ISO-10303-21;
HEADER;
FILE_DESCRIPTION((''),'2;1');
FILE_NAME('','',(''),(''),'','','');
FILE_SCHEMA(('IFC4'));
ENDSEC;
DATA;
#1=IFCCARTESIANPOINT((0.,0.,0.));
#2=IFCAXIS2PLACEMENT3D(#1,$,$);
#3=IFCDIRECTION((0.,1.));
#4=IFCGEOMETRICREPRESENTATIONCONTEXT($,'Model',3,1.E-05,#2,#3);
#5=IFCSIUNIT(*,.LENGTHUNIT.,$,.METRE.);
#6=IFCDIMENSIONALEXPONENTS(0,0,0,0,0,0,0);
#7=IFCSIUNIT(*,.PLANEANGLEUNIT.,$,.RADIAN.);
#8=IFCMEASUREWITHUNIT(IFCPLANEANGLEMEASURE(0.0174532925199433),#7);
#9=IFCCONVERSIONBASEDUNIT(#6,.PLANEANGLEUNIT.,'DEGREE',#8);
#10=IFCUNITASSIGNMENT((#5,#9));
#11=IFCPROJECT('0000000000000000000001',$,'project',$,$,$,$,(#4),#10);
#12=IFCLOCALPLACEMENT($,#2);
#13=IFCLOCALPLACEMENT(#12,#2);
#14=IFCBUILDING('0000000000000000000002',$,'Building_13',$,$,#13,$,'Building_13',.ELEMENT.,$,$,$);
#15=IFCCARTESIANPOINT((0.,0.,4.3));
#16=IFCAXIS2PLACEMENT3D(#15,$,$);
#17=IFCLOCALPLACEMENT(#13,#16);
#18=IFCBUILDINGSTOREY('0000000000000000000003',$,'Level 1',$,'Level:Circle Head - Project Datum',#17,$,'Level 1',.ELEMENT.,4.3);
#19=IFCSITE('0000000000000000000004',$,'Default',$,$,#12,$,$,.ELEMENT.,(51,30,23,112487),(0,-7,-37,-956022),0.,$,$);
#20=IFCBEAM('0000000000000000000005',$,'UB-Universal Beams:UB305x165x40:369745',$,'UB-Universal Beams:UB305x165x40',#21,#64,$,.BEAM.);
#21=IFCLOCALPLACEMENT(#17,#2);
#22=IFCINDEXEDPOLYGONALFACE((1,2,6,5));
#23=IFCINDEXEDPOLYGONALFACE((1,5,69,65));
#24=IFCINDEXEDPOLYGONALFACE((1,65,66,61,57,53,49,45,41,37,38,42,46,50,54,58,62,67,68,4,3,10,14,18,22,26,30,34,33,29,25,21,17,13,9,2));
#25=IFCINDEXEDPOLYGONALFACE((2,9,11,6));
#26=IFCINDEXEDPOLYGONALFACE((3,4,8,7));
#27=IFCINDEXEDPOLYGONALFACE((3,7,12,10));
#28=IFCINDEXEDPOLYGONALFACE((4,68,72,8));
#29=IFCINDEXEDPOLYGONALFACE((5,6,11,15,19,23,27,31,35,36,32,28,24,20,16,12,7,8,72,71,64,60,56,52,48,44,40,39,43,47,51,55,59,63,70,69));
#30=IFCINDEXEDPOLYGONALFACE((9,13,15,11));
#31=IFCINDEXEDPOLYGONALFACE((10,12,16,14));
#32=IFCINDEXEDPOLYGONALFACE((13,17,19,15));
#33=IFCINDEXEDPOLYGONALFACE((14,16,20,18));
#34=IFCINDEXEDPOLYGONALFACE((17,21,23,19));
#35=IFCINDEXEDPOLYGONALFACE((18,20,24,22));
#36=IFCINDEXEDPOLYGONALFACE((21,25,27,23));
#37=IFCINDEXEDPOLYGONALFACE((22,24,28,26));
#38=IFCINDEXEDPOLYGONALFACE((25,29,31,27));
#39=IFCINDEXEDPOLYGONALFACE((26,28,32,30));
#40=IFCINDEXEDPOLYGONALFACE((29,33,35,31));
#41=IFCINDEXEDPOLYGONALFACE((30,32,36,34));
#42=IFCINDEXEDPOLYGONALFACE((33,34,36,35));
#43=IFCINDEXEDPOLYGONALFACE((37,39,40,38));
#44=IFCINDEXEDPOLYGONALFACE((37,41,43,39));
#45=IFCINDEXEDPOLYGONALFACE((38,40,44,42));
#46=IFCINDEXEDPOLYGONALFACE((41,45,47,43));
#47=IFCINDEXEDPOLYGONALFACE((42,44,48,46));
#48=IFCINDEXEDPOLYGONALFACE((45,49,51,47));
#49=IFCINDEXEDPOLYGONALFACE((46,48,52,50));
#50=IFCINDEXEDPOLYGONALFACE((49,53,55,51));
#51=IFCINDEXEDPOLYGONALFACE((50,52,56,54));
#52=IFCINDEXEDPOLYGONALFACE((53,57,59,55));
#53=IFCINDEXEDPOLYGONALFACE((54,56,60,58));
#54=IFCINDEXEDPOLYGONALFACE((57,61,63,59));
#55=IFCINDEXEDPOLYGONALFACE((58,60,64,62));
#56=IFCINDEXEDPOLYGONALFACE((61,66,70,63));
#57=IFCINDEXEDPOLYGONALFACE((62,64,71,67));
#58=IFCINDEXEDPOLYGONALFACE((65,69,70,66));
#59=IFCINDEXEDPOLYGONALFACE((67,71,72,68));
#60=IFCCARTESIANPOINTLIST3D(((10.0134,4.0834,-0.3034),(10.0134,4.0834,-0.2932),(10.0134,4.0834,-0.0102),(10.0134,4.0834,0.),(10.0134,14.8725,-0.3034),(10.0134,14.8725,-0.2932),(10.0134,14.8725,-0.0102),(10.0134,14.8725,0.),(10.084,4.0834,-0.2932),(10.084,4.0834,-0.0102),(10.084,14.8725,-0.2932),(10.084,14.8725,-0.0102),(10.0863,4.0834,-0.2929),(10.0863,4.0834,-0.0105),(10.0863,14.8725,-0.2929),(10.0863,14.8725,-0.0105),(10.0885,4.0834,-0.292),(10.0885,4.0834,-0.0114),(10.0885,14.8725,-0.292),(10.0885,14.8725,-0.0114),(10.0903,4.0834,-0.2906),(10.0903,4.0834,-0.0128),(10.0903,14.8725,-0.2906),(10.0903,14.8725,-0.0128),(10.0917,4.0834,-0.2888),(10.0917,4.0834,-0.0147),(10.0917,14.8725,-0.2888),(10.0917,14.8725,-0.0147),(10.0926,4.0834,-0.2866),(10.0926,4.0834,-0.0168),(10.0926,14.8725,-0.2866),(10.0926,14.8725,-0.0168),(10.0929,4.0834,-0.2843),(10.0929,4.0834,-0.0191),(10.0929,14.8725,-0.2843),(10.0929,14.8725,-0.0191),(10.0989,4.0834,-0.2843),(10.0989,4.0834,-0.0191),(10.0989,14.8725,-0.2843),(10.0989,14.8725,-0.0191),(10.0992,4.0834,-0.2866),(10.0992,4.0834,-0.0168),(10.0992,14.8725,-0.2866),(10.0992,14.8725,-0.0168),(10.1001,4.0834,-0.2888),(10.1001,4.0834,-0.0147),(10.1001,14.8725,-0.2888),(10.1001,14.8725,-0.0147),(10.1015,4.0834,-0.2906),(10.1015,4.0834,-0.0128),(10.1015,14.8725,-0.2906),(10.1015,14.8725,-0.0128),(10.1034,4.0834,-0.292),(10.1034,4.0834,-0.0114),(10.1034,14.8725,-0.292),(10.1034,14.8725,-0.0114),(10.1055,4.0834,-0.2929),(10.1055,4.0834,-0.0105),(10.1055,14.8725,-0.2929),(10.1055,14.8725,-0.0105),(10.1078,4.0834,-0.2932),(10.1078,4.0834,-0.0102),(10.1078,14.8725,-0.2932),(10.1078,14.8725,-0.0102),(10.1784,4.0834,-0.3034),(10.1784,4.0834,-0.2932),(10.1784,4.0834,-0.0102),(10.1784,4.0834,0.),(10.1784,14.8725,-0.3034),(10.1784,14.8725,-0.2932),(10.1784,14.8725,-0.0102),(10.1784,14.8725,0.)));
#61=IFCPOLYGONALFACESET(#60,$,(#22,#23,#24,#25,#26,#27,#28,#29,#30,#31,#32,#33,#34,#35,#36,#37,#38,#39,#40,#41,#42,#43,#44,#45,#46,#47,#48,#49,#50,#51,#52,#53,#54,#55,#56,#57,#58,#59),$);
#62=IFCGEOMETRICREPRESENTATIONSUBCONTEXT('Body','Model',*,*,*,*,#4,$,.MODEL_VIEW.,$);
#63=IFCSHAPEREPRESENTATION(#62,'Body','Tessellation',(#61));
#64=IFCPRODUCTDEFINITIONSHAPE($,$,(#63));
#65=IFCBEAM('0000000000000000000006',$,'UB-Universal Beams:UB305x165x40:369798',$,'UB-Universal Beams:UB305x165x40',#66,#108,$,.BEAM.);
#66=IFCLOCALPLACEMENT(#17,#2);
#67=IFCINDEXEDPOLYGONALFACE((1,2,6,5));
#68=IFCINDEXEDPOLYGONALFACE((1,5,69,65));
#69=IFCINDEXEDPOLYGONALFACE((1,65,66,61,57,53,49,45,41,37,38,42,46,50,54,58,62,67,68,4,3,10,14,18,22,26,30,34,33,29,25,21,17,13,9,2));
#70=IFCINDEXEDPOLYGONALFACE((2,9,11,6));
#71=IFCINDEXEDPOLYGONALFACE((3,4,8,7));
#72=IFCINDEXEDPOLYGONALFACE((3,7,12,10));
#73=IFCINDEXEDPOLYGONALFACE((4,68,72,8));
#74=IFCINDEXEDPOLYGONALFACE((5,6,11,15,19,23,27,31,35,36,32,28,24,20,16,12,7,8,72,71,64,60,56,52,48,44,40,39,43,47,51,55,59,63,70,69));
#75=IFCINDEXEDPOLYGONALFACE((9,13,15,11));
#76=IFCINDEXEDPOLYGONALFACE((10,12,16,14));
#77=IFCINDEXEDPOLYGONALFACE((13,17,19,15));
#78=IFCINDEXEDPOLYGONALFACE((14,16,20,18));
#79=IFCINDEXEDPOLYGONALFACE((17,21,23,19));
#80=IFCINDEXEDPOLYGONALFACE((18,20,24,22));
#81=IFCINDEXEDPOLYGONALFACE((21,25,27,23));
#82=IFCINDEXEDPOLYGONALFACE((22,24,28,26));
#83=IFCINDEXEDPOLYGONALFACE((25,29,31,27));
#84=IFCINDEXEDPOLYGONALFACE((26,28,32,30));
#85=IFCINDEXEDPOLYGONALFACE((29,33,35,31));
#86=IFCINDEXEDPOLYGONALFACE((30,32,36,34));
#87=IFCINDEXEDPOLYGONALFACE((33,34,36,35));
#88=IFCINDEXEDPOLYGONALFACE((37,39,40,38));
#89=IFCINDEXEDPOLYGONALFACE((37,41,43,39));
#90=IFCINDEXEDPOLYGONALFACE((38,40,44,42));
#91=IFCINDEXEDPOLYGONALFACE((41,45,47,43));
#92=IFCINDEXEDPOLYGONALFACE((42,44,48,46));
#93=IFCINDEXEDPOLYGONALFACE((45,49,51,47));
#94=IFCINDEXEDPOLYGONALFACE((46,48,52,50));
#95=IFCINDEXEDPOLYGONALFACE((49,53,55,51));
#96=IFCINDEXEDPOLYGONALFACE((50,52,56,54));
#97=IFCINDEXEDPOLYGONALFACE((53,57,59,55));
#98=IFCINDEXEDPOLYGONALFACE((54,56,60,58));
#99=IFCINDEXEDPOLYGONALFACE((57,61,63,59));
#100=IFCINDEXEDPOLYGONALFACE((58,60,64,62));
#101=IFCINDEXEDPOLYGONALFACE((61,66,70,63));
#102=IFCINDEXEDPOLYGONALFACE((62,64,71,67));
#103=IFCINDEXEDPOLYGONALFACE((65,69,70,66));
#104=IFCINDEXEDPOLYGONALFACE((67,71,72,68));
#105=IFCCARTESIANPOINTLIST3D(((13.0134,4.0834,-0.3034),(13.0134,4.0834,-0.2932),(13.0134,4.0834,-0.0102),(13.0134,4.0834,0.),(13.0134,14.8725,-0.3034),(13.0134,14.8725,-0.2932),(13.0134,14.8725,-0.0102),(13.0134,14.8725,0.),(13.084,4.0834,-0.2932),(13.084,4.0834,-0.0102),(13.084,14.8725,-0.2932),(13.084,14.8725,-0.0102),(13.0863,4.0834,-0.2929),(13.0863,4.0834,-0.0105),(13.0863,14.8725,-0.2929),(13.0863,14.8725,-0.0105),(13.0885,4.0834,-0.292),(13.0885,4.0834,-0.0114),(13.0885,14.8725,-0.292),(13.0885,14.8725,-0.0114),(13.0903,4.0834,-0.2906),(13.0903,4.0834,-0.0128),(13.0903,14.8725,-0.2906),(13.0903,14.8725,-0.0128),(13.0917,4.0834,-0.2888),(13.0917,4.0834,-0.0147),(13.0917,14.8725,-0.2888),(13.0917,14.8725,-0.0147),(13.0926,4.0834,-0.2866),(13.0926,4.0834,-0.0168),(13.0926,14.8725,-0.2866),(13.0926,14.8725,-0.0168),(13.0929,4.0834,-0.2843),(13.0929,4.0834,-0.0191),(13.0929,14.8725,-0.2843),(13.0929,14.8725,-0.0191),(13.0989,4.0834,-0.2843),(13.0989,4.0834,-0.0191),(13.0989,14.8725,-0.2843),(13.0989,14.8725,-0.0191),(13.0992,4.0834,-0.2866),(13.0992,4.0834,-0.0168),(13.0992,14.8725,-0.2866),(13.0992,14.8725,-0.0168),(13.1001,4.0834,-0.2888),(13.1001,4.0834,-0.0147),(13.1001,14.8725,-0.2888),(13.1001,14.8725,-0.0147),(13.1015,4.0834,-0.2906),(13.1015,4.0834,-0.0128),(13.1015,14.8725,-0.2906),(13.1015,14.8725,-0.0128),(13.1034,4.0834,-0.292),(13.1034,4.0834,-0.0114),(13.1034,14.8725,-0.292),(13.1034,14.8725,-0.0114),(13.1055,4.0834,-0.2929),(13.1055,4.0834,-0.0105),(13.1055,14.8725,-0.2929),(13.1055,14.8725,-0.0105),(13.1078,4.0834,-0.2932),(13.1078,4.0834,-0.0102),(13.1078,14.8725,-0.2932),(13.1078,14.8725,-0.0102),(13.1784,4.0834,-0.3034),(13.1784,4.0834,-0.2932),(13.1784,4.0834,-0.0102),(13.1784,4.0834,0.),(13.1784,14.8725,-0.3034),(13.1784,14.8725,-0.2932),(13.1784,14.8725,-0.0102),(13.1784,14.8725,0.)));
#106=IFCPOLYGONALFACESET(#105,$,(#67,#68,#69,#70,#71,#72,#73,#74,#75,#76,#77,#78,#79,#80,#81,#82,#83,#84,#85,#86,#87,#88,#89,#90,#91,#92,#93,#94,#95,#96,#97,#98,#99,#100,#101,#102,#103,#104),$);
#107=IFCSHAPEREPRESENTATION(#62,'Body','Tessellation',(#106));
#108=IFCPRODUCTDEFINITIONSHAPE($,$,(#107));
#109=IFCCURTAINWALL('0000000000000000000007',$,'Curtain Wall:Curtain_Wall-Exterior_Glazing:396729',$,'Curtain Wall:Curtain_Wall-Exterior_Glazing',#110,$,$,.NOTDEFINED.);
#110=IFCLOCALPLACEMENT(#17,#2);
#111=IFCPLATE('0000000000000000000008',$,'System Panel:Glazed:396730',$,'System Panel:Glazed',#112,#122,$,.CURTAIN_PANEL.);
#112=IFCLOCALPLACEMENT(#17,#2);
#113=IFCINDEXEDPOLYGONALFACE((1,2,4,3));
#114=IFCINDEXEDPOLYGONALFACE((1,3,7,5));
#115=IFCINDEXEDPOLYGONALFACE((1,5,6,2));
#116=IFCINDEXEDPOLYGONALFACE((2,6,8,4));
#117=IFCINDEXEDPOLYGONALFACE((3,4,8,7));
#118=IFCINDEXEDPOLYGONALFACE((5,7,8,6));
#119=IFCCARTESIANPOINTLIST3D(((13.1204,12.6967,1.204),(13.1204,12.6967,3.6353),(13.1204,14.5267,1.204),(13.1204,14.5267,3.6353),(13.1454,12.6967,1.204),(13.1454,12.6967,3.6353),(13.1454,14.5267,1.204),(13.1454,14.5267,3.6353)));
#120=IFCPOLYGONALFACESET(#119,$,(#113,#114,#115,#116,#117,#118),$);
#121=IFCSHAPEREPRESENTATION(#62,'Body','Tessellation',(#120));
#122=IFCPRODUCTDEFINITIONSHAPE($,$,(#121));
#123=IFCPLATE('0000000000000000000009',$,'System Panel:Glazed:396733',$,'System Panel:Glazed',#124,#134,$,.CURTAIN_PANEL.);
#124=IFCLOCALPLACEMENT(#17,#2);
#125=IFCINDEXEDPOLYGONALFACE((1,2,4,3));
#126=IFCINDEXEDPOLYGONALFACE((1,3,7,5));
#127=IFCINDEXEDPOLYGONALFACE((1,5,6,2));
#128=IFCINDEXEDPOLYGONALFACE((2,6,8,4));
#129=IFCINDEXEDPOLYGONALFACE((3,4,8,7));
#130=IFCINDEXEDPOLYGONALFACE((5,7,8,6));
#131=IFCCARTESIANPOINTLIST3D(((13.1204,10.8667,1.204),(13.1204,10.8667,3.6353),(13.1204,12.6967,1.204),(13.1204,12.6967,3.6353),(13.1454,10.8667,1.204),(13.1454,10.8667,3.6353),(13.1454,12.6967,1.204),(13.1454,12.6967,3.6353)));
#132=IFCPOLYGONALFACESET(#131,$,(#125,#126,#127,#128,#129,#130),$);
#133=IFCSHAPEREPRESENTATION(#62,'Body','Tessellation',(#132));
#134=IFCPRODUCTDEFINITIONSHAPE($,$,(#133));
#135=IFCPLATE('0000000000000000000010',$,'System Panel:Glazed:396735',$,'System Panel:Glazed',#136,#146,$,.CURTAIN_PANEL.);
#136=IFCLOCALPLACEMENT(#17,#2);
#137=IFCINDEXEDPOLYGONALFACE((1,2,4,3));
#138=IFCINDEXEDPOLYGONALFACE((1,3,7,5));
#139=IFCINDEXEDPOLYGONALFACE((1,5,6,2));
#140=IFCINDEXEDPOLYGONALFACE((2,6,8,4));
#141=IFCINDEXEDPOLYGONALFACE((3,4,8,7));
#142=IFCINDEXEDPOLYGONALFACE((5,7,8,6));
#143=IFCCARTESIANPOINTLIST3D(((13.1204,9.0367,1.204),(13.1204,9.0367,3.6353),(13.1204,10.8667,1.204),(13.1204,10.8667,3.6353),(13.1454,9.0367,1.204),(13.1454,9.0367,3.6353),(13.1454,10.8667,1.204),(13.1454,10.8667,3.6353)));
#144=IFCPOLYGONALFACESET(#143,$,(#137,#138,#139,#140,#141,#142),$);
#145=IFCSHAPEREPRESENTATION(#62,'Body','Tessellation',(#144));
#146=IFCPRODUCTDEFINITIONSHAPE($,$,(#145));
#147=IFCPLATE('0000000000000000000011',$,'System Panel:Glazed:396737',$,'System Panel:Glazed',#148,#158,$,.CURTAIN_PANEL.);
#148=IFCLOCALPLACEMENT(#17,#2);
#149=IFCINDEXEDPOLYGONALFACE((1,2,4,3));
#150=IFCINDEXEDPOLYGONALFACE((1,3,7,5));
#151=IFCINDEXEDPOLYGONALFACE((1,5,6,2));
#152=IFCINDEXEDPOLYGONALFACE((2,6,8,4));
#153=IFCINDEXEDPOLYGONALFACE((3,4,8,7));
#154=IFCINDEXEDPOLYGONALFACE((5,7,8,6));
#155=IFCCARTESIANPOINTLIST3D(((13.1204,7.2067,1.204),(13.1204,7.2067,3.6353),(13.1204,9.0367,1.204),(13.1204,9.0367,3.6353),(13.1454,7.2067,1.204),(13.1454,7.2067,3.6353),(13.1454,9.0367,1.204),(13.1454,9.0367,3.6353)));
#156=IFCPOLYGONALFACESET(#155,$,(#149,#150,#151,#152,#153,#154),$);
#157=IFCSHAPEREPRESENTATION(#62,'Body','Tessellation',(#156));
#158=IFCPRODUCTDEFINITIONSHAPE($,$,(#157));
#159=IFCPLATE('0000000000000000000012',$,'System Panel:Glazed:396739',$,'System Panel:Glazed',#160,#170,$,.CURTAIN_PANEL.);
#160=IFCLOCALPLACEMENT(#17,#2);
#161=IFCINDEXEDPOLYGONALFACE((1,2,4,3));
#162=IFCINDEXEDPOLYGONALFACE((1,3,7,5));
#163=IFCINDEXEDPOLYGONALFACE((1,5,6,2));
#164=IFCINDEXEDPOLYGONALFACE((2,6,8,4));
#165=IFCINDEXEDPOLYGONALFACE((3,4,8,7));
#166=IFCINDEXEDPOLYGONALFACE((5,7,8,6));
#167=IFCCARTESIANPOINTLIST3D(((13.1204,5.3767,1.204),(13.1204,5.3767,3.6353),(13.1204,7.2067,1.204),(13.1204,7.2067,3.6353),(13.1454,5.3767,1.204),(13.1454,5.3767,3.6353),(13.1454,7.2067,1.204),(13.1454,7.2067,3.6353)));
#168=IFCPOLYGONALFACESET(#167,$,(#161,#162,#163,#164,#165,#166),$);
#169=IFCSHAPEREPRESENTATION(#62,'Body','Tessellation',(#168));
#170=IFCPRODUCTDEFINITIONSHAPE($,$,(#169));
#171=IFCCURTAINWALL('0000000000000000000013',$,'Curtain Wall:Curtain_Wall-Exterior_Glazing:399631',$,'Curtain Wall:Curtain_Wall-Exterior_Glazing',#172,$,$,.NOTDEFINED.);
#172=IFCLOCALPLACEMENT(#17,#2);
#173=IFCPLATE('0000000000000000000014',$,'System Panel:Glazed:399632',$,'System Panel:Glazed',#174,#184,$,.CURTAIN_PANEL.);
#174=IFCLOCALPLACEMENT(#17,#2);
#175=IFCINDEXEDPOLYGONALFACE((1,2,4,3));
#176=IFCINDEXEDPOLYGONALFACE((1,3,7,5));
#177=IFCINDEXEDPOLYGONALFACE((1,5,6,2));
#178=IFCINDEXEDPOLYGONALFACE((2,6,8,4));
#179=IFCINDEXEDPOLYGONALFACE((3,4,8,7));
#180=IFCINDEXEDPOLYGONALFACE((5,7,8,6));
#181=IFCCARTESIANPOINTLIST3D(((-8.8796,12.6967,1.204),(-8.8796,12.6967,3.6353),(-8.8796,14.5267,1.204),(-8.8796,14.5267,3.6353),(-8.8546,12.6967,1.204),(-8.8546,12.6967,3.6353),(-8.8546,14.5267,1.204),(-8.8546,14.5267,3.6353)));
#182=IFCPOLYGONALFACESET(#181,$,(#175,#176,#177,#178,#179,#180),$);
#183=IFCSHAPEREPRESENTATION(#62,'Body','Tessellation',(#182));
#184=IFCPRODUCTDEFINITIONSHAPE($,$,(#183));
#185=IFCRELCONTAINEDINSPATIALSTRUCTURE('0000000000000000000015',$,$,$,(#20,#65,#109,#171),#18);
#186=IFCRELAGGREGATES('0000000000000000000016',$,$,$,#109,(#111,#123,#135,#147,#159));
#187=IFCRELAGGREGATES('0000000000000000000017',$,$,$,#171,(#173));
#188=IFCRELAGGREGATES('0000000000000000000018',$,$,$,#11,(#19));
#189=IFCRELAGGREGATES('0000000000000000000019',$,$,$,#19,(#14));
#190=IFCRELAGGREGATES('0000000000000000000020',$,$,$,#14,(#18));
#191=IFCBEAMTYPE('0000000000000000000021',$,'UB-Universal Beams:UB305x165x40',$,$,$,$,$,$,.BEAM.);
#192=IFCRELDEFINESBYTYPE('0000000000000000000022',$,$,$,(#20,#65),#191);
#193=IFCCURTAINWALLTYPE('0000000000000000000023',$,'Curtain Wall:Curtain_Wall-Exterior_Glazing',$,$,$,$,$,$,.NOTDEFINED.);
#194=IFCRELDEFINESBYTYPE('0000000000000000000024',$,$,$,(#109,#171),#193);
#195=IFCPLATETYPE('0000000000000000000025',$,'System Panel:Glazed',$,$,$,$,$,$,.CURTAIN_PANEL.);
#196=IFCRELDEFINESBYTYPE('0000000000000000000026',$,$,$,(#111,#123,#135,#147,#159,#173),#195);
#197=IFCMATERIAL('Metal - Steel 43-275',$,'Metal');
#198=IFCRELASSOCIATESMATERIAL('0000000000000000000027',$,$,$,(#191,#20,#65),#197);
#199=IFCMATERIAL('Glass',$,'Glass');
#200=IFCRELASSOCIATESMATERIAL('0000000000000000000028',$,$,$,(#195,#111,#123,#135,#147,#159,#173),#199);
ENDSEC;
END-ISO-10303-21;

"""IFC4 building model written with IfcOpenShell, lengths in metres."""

from ifc_helpers import new_model, entity, si_unit, converted_unit, direction, frame, origin, place, context, subcontext, project, spatial, line, arc, indexed_curve, outline, extrude, source, transform, mapped, material, type_object, type_shapes, element, aggregate, save


model = new_model("IFC4")

# Units and contexts
model_context = context("Model", 3, precision=1e-05, world=origin(), true_north=direction((0.0, 1.0)))
body_context = subcontext(model_context, "Body", "Model", "MODEL_VIEW")
ifc_project = project(units=[si_unit("LENGTHUNIT", "METRE"), converted_unit("PLANEANGLEUNIT", "DEGREE", entity("IfcPlaneAngleMeasure", 0.0174532925199433), si_unit("PLANEANGLEUNIT", "RADIAN"), dimensions=[0, 0, 0, 0, 0, 0, 0])], contexts=[model_context])

# Site, building, storey
site_placement = place(None, origin())
site = spatial("IfcSite", under=ifc_project, at=site_placement, Name="Default", CompositionType="ELEMENT", RefLatitude=(51, 30, 23, 112487), RefLongitude=(0, -7, -37, -956022), RefElevation=0.0)
building_placement = place(site_placement, origin())
building = spatial("IfcBuilding", under=site, at=building_placement, Name="Building_13", LongName="Building_13", CompositionType="ELEMENT")
storey_placement = place(building_placement, frame((0.0, 0.0, 4.3)))
storey = spatial("IfcBuildingStorey", under=building, at=storey_placement, Name="Level 1", ObjectType="Level:Circle Head - Project Datum", LongName="Level 1", CompositionType="ELEMENT", Elevation=4.3)

# Beams
ifc_material_1 = material(Name="Metal - Steel 43-275", Category="Metal")
beam_type_1 = type_object("IfcBeamType", Name="UB-Universal Beams:UB305x165x40", PredefinedType="BEAM", material=ifc_material_1)
shared_shape_1 = source(origin(), body_context, "Body", "SweptSolid", [
    extrude(outline(indexed_curve([(-0.0825, -0.1415), (-0.0825, -0.1517), (0.0825, -0.1517), (0.0825, -0.1415), (0.0119, -0.1415), (0.0056, -0.1389), (0.003, -0.1326), (0.003, 0.1326), (0.0056, 0.1389), (0.0119, 0.1415), (0.0825, 0.1415), (0.0825, 0.1517), (-0.0825, 0.1517), (-0.0825, 0.1415), (-0.0119, 0.1415), (-0.0056, 0.1389), (-0.003, 0.1326), (-0.003, -0.1326), (-0.0056, -0.1389), (-0.0119, -0.1415)], segments=[line(1, 2, 3, 4, 5), arc(5, 6, 7), line(7, 8), arc(8, 9, 10), line(10, 11, 12, 13, 14, 15), arc(15, 16, 17), line(17, 18), arc(18, 19, 20), line(20, 1)], self_intersect=False)), frame((-5.3945, 0.0, 0.0), z_axis=(-1.0, 0.0, 0.0), x_axis=(0.0, -1.0, 0.0)), (0.0, 0.0, -1.0), 10.7891),
])
type_shapes(beam_type_1, [shared_shape_1])
for number, where, z_axis, x_axis, name in (
    (1, (10.0959, 9.4779, -0.1517), (0.0, 0.0, 1.0), (0.0, 1.0, 0.0), "UB-Universal Beams:UB305x165x40:369745"),
    (2, (13.0959, 9.4779, -0.1517), (0.0, 0.0, 1.0), (0.0, -1.0, 0.0), "UB-Universal Beams:UB305x165x40:369798"),
):
    element("IfcBeam", number, at=place(storey_placement, frame(where, z_axis=z_axis, x_axis=x_axis)), inside=storey, type_object=beam_type_1, material=ifc_material_1, Name=name, ObjectType="UB-Universal Beams:UB305x165x40", PredefinedType="BEAM", context=body_context, shape_type="MappedRepresentation", body=[
        mapped(shared_shape_1, transform((0.0, 0.0, 0.0), scale=1.0)),
    ])

# Curtain walls, plates
curtain_wall_type = type_object("IfcCurtainWallType", Name="Curtain Wall:Curtain_Wall-Exterior_Glazing", PredefinedType="NOTDEFINED")
curtain_wall_1_placement = place(storey_placement, frame((0.0, 0.0, -4.3)))
curtain_wall_1 = element("IfcCurtainWall", 3, at=curtain_wall_1_placement, inside=storey, type_object=curtain_wall_type, Name="Curtain Wall:Curtain_Wall-Exterior_Glazing:396729", ObjectType="Curtain Wall:Curtain_Wall-Exterior_Glazing", PredefinedType="NOTDEFINED")
ifc_material_2 = material(Name="Glass", Category="Glass")
plate_type_1 = type_object("IfcPlateType", Name="System Panel:Glazed", PredefinedType="CURTAIN_PANEL", material=ifc_material_2)
shared_shape_2 = source(origin(), body_context, "Body", "SweptSolid", [
    extrude(outline(indexed_curve([(-0.0125, -0.915), (0.0125, -0.915), (0.0125, 0.915), (-0.0125, 0.915), (-0.0125, -0.915)], self_intersect=False)), frame((0.0, 0.037, 0.0), z_axis=(0.0, 0.0, 1.0), x_axis=(0.0, 1.0, 0.0)), (0.0, 0.0, 1.0), 2.4313),
])
type_shapes(plate_type_1, [shared_shape_2])
plate_1_placement = place(curtain_wall_1_placement, frame((13.0959, 13.6117, 5.504), z_axis=(0.0, 0.0, 1.0), x_axis=(0.0, -1.0, 0.0)))
plate_1 = element("IfcPlate", 4, at=plate_1_placement, type_object=plate_type_1, material=ifc_material_2, Name="System Panel:Glazed:396730", ObjectType="System Panel:Glazed", PredefinedType="CURTAIN_PANEL", context=body_context, shape_type="MappedRepresentation", body=[
    mapped(shared_shape_2, transform((0.0, 0.0, 0.0), scale=1.0)),
])
plate_2_placement = place(curtain_wall_1_placement, frame((13.0959, 11.7817, 5.504), z_axis=(0.0, 0.0, 1.0), x_axis=(0.0, -1.0, 0.0)))
plate_2 = element("IfcPlate", 5, at=plate_2_placement, type_object=plate_type_1, material=ifc_material_2, Name="System Panel:Glazed:396733", ObjectType="System Panel:Glazed", PredefinedType="CURTAIN_PANEL", context=body_context, shape_type="MappedRepresentation", body=[
    mapped(shared_shape_2, transform((0.0, 0.0, 0.0), scale=1.0)),
])
plate_3_placement = place(curtain_wall_1_placement, frame((13.0959, 9.9517, 5.504), z_axis=(0.0, 0.0, 1.0), x_axis=(0.0, -1.0, 0.0)))
plate_3 = element("IfcPlate", 6, at=plate_3_placement, type_object=plate_type_1, material=ifc_material_2, Name="System Panel:Glazed:396735", ObjectType="System Panel:Glazed", PredefinedType="CURTAIN_PANEL", context=body_context, shape_type="MappedRepresentation", body=[
    mapped(shared_shape_2, transform((0.0, 0.0, 0.0), scale=1.0)),
])
plate_4_placement = place(curtain_wall_1_placement, frame((13.0959, 8.1217, 5.504), z_axis=(0.0, 0.0, 1.0), x_axis=(0.0, -1.0, 0.0)))
plate_4 = element("IfcPlate", 7, at=plate_4_placement, type_object=plate_type_1, material=ifc_material_2, Name="System Panel:Glazed:396737", ObjectType="System Panel:Glazed", PredefinedType="CURTAIN_PANEL", context=body_context, shape_type="MappedRepresentation", body=[
    mapped(shared_shape_2, transform((0.0, 0.0, 0.0), scale=1.0)),
])
plate_5_placement = place(curtain_wall_1_placement, frame((13.0959, 6.2917, 5.504), z_axis=(0.0, 0.0, 1.0), x_axis=(0.0, -1.0, 0.0)))
plate_5 = element("IfcPlate", 8, at=plate_5_placement, type_object=plate_type_1, material=ifc_material_2, Name="System Panel:Glazed:396739", ObjectType="System Panel:Glazed", PredefinedType="CURTAIN_PANEL", context=body_context, shape_type="MappedRepresentation", body=[
    mapped(shared_shape_2, transform((0.0, 0.0, 0.0), scale=1.0)),
])
curtain_wall_2_placement = place(storey_placement, frame((0.0, 0.0, -4.3)))
curtain_wall_2 = element("IfcCurtainWall", 9, at=curtain_wall_2_placement, inside=storey, type_object=curtain_wall_type, Name="Curtain Wall:Curtain_Wall-Exterior_Glazing:399631", ObjectType="Curtain Wall:Curtain_Wall-Exterior_Glazing", PredefinedType="NOTDEFINED")
plate_6_placement = place(curtain_wall_2_placement, frame((-8.9041, 13.6117, 5.504), z_axis=(0.0, 0.0, 1.0), x_axis=(0.0, -1.0, 0.0)))
plate_6 = element("IfcPlate", 10, at=plate_6_placement, type_object=plate_type_1, material=ifc_material_2, Name="System Panel:Glazed:399632", ObjectType="System Panel:Glazed", PredefinedType="CURTAIN_PANEL", context=body_context, shape_type="MappedRepresentation", body=[
    mapped(shared_shape_2, transform((0.0, 0.0, 0.0), scale=1.0)),
])

aggregate(curtain_wall_1, [plate_1, plate_2, plate_3, plate_4, plate_5])
aggregate(curtain_wall_2, [plate_6])

save(model, "model.ifc")
